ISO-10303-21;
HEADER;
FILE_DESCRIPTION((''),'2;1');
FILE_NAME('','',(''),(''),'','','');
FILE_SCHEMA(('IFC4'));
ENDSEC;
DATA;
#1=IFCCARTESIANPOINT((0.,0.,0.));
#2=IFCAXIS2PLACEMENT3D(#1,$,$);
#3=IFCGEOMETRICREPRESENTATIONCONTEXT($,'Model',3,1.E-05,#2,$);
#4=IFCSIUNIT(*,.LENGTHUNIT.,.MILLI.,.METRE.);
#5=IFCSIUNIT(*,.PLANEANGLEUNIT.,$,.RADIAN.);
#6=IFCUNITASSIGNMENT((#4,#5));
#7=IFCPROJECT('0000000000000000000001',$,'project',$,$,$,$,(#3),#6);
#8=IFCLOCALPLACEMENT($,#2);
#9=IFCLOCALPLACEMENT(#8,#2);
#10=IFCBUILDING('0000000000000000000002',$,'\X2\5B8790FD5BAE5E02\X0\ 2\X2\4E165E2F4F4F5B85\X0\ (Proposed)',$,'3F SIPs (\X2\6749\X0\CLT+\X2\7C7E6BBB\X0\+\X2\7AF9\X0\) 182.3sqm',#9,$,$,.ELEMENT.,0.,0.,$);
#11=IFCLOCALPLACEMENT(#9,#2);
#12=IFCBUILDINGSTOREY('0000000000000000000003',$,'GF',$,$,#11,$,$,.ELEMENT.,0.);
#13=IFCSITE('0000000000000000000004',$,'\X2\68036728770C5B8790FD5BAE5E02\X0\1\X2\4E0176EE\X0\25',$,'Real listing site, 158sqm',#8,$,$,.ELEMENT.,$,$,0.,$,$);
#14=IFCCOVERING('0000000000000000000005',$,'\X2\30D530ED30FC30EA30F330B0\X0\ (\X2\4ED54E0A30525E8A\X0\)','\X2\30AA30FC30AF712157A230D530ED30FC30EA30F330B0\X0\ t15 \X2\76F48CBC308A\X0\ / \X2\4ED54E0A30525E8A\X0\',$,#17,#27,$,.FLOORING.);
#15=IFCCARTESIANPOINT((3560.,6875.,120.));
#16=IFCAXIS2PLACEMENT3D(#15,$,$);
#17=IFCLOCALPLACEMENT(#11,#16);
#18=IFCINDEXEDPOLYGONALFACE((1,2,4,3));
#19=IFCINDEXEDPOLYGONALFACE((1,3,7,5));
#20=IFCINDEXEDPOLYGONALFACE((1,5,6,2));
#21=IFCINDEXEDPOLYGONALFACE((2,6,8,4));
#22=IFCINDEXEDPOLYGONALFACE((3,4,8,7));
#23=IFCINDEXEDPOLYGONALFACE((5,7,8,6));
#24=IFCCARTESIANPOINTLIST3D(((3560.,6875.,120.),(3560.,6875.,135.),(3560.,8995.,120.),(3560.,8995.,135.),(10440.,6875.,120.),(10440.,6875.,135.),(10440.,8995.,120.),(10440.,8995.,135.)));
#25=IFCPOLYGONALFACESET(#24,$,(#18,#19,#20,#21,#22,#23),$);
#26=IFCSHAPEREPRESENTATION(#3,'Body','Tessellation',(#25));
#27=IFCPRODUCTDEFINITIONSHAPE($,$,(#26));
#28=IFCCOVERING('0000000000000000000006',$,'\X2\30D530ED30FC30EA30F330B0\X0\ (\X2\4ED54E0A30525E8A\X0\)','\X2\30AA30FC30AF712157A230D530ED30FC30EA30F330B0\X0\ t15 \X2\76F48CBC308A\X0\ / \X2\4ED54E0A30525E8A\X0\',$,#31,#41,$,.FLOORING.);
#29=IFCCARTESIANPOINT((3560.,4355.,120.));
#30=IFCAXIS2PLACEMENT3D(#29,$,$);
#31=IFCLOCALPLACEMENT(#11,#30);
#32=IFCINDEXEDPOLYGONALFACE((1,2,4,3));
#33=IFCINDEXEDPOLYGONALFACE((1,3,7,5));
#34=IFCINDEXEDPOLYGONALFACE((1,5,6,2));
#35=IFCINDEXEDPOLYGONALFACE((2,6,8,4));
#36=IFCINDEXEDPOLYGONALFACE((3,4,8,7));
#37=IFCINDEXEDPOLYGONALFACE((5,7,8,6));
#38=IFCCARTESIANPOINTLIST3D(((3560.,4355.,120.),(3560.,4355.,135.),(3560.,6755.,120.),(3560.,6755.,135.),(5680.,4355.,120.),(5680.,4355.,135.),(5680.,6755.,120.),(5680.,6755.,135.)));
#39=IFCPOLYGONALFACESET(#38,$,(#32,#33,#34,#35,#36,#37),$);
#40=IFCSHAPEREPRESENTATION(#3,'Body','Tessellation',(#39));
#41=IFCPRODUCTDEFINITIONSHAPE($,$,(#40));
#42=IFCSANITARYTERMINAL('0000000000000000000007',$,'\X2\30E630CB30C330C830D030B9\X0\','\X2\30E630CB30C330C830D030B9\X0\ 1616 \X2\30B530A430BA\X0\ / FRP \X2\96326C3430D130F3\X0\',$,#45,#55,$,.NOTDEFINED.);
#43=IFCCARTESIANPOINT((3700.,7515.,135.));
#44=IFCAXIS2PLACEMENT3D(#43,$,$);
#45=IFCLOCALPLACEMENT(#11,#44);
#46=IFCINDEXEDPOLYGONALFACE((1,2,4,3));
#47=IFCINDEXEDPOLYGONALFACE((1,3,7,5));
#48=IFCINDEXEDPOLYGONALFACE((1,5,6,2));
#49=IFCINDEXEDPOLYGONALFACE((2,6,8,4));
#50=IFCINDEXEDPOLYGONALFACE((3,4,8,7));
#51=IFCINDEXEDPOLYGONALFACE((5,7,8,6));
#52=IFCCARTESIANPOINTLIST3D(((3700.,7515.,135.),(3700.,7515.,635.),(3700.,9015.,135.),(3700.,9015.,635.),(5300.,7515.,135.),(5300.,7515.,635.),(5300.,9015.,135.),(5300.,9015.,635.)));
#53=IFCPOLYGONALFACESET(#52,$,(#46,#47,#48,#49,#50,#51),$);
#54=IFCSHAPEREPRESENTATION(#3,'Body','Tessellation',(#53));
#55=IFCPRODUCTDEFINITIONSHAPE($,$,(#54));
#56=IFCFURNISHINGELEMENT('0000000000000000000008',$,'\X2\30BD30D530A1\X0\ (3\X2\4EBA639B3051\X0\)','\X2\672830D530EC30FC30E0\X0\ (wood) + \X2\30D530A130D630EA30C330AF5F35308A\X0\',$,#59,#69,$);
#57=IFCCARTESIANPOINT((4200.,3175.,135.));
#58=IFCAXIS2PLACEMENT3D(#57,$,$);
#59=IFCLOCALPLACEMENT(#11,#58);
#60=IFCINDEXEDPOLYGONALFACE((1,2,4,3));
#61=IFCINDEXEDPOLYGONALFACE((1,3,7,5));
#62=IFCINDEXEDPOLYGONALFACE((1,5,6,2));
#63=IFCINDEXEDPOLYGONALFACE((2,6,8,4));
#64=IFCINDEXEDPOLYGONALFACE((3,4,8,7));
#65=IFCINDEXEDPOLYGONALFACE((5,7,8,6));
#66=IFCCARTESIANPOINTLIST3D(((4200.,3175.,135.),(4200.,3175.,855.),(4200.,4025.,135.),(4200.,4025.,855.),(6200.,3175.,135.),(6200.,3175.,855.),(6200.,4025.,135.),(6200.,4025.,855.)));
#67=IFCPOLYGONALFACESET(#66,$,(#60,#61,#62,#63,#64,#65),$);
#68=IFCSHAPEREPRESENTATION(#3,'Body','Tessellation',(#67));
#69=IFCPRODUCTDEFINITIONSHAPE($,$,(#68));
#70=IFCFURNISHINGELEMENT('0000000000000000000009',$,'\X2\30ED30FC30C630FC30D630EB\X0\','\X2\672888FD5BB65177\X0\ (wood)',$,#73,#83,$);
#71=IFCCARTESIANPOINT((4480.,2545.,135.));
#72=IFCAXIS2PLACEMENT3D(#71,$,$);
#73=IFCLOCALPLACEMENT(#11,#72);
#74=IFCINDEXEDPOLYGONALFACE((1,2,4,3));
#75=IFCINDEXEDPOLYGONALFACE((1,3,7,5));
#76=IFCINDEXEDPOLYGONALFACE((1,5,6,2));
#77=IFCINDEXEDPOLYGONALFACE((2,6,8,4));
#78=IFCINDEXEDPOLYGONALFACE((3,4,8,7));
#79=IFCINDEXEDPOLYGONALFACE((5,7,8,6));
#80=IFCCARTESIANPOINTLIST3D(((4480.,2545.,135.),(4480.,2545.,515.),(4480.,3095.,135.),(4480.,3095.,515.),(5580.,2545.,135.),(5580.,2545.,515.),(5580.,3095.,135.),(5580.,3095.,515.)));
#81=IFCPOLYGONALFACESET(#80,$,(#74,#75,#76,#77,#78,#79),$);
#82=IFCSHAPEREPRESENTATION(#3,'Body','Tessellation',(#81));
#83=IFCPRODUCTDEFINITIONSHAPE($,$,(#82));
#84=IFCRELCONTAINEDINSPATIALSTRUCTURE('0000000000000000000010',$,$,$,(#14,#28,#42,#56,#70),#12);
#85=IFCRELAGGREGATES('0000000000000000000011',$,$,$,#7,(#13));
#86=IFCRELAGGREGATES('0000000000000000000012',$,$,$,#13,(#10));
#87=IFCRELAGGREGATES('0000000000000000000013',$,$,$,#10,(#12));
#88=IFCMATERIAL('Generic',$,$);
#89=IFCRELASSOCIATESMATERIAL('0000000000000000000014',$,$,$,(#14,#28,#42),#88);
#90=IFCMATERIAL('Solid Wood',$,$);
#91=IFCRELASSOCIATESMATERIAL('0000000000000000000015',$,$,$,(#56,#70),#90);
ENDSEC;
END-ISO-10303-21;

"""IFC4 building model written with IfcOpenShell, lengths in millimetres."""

from ifc_helpers import new_model, si_unit, frame, frame_2d, origin, place, context, project, spatial, rectangle, extrude, material, element, save


model = new_model("IFC4")

# Units and contexts
model_context = context("Model", 3, precision=1e-05, world=origin())
ifc_project = project(units=[si_unit("LENGTHUNIT", "METRE", prefix="MILLI"), si_unit("PLANEANGLEUNIT", "RADIAN")], contexts=[model_context])

# Site, building, storey
site_placement = place(None, origin())
site = spatial("IfcSite", under=ifc_project, at=site_placement, Name="栃木県宇都宮市1丁目25", ObjectType="Real listing site, 158sqm", CompositionType="ELEMENT", RefElevation=0.0)
building_placement = place(site_placement, origin())
building = spatial("IfcBuilding", under=site, at=building_placement, Name="宇都宮市 2世帯住宅 (Proposed)", ObjectType="3F SIPs (杉CLT+籾殻+竹) 182.3sqm", CompositionType="ELEMENT", ElevationOfRefHeight=0.0, ElevationOfTerrain=0.0)
storey_placement = place(building_placement, origin())
storey = spatial("IfcBuildingStorey", under=building, at=storey_placement, Name="GF", CompositionType="ELEMENT", Elevation=0.0)

# Shared definitions
ifc_material_1 = material(Name="Solid Wood")

# Coverings
ifc_material_2 = material(Name="Generic")
covering_1_placement = place(storey_placement, frame((3560.0, 6875.0, 120.0)))
element("IfcCovering", 1, at=covering_1_placement, inside=storey, material=ifc_material_2, Name="フローリング (仕上げ床)", Description="オーク無垢フローリング t15 直貼り / 仕上げ床", PredefinedType="FLOORING", context=model_context, shape_type="SweptSolid", body=[
    extrude(rectangle(XDim=6880.0, YDim=2120.0, at=frame_2d((3440.0, 1060.0))), frame((3560.0, 6875.0, 120.0)), (0.0, 0.0, 1.0), 15.0),
])
covering_2_placement = place(storey_placement, frame((3560.0, 4355.0, 120.0)))
element("IfcCovering", 2, at=covering_2_placement, inside=storey, material=ifc_material_2, Name="フローリング (仕上げ床)", Description="オーク無垢フローリング t15 直貼り / 仕上げ床", PredefinedType="FLOORING", context=model_context, shape_type="SweptSolid", body=[
    extrude(rectangle(XDim=2120.0, YDim=2400.0, at=frame_2d((1060.0, 1200.0))), frame((3560.0, 4355.0, 120.0)), (0.0, 0.0, 1.0), 15.0),
])

# Sanitary terminal
sanitary_terminal_placement = place(storey_placement, frame((3700.0, 7515.0, 135.0)))
element("IfcSanitaryTerminal", 3, at=sanitary_terminal_placement, inside=storey, material=ifc_material_2, Name="ユニットバス", Description="ユニットバス 1616 サイズ / FRP 防水パン", PredefinedType="NOTDEFINED", context=model_context, shape_type="SweptSolid", body=[
    extrude(rectangle(XDim=1600.0, YDim=1500.0, at=frame_2d((800.0, 750.0))), frame((3700.0, 7515.0, 135.0)), (0.0, 0.0, 1.0), 500.0),
])

# Furnishing elements
furnishing_1_placement = place(storey_placement, frame((4200.0, 3175.0, 135.0)))
element("IfcFurnishingElement", 4, at=furnishing_1_placement, inside=storey, material=ifc_material_1, Name="ソファ (3人掛け)", Description="木フレーム (wood) + ファブリック張り", context=model_context, shape_type="SweptSolid", body=[
    extrude(rectangle(XDim=2000.0, YDim=850.0, at=frame_2d((1000.0, 425.0))), frame((4200.0, 3175.0, 135.0)), (0.0, 0.0, 1.0), 720.0),
])
furnishing_2_placement = place(storey_placement, frame((4480.0, 2545.0, 135.0)))
element("IfcFurnishingElement", 5, at=furnishing_2_placement, inside=storey, material=ifc_material_1, Name="ローテーブル", Description="木製家具 (wood)", context=model_context, shape_type="SweptSolid", body=[
    extrude(rectangle(XDim=1100.0, YDim=550.0, at=frame_2d((550.0, 275.0))), frame((4480.0, 2545.0, 135.0)), (0.0, 0.0, 1.0), 380.0),
])

save(model, "model.ifc")
